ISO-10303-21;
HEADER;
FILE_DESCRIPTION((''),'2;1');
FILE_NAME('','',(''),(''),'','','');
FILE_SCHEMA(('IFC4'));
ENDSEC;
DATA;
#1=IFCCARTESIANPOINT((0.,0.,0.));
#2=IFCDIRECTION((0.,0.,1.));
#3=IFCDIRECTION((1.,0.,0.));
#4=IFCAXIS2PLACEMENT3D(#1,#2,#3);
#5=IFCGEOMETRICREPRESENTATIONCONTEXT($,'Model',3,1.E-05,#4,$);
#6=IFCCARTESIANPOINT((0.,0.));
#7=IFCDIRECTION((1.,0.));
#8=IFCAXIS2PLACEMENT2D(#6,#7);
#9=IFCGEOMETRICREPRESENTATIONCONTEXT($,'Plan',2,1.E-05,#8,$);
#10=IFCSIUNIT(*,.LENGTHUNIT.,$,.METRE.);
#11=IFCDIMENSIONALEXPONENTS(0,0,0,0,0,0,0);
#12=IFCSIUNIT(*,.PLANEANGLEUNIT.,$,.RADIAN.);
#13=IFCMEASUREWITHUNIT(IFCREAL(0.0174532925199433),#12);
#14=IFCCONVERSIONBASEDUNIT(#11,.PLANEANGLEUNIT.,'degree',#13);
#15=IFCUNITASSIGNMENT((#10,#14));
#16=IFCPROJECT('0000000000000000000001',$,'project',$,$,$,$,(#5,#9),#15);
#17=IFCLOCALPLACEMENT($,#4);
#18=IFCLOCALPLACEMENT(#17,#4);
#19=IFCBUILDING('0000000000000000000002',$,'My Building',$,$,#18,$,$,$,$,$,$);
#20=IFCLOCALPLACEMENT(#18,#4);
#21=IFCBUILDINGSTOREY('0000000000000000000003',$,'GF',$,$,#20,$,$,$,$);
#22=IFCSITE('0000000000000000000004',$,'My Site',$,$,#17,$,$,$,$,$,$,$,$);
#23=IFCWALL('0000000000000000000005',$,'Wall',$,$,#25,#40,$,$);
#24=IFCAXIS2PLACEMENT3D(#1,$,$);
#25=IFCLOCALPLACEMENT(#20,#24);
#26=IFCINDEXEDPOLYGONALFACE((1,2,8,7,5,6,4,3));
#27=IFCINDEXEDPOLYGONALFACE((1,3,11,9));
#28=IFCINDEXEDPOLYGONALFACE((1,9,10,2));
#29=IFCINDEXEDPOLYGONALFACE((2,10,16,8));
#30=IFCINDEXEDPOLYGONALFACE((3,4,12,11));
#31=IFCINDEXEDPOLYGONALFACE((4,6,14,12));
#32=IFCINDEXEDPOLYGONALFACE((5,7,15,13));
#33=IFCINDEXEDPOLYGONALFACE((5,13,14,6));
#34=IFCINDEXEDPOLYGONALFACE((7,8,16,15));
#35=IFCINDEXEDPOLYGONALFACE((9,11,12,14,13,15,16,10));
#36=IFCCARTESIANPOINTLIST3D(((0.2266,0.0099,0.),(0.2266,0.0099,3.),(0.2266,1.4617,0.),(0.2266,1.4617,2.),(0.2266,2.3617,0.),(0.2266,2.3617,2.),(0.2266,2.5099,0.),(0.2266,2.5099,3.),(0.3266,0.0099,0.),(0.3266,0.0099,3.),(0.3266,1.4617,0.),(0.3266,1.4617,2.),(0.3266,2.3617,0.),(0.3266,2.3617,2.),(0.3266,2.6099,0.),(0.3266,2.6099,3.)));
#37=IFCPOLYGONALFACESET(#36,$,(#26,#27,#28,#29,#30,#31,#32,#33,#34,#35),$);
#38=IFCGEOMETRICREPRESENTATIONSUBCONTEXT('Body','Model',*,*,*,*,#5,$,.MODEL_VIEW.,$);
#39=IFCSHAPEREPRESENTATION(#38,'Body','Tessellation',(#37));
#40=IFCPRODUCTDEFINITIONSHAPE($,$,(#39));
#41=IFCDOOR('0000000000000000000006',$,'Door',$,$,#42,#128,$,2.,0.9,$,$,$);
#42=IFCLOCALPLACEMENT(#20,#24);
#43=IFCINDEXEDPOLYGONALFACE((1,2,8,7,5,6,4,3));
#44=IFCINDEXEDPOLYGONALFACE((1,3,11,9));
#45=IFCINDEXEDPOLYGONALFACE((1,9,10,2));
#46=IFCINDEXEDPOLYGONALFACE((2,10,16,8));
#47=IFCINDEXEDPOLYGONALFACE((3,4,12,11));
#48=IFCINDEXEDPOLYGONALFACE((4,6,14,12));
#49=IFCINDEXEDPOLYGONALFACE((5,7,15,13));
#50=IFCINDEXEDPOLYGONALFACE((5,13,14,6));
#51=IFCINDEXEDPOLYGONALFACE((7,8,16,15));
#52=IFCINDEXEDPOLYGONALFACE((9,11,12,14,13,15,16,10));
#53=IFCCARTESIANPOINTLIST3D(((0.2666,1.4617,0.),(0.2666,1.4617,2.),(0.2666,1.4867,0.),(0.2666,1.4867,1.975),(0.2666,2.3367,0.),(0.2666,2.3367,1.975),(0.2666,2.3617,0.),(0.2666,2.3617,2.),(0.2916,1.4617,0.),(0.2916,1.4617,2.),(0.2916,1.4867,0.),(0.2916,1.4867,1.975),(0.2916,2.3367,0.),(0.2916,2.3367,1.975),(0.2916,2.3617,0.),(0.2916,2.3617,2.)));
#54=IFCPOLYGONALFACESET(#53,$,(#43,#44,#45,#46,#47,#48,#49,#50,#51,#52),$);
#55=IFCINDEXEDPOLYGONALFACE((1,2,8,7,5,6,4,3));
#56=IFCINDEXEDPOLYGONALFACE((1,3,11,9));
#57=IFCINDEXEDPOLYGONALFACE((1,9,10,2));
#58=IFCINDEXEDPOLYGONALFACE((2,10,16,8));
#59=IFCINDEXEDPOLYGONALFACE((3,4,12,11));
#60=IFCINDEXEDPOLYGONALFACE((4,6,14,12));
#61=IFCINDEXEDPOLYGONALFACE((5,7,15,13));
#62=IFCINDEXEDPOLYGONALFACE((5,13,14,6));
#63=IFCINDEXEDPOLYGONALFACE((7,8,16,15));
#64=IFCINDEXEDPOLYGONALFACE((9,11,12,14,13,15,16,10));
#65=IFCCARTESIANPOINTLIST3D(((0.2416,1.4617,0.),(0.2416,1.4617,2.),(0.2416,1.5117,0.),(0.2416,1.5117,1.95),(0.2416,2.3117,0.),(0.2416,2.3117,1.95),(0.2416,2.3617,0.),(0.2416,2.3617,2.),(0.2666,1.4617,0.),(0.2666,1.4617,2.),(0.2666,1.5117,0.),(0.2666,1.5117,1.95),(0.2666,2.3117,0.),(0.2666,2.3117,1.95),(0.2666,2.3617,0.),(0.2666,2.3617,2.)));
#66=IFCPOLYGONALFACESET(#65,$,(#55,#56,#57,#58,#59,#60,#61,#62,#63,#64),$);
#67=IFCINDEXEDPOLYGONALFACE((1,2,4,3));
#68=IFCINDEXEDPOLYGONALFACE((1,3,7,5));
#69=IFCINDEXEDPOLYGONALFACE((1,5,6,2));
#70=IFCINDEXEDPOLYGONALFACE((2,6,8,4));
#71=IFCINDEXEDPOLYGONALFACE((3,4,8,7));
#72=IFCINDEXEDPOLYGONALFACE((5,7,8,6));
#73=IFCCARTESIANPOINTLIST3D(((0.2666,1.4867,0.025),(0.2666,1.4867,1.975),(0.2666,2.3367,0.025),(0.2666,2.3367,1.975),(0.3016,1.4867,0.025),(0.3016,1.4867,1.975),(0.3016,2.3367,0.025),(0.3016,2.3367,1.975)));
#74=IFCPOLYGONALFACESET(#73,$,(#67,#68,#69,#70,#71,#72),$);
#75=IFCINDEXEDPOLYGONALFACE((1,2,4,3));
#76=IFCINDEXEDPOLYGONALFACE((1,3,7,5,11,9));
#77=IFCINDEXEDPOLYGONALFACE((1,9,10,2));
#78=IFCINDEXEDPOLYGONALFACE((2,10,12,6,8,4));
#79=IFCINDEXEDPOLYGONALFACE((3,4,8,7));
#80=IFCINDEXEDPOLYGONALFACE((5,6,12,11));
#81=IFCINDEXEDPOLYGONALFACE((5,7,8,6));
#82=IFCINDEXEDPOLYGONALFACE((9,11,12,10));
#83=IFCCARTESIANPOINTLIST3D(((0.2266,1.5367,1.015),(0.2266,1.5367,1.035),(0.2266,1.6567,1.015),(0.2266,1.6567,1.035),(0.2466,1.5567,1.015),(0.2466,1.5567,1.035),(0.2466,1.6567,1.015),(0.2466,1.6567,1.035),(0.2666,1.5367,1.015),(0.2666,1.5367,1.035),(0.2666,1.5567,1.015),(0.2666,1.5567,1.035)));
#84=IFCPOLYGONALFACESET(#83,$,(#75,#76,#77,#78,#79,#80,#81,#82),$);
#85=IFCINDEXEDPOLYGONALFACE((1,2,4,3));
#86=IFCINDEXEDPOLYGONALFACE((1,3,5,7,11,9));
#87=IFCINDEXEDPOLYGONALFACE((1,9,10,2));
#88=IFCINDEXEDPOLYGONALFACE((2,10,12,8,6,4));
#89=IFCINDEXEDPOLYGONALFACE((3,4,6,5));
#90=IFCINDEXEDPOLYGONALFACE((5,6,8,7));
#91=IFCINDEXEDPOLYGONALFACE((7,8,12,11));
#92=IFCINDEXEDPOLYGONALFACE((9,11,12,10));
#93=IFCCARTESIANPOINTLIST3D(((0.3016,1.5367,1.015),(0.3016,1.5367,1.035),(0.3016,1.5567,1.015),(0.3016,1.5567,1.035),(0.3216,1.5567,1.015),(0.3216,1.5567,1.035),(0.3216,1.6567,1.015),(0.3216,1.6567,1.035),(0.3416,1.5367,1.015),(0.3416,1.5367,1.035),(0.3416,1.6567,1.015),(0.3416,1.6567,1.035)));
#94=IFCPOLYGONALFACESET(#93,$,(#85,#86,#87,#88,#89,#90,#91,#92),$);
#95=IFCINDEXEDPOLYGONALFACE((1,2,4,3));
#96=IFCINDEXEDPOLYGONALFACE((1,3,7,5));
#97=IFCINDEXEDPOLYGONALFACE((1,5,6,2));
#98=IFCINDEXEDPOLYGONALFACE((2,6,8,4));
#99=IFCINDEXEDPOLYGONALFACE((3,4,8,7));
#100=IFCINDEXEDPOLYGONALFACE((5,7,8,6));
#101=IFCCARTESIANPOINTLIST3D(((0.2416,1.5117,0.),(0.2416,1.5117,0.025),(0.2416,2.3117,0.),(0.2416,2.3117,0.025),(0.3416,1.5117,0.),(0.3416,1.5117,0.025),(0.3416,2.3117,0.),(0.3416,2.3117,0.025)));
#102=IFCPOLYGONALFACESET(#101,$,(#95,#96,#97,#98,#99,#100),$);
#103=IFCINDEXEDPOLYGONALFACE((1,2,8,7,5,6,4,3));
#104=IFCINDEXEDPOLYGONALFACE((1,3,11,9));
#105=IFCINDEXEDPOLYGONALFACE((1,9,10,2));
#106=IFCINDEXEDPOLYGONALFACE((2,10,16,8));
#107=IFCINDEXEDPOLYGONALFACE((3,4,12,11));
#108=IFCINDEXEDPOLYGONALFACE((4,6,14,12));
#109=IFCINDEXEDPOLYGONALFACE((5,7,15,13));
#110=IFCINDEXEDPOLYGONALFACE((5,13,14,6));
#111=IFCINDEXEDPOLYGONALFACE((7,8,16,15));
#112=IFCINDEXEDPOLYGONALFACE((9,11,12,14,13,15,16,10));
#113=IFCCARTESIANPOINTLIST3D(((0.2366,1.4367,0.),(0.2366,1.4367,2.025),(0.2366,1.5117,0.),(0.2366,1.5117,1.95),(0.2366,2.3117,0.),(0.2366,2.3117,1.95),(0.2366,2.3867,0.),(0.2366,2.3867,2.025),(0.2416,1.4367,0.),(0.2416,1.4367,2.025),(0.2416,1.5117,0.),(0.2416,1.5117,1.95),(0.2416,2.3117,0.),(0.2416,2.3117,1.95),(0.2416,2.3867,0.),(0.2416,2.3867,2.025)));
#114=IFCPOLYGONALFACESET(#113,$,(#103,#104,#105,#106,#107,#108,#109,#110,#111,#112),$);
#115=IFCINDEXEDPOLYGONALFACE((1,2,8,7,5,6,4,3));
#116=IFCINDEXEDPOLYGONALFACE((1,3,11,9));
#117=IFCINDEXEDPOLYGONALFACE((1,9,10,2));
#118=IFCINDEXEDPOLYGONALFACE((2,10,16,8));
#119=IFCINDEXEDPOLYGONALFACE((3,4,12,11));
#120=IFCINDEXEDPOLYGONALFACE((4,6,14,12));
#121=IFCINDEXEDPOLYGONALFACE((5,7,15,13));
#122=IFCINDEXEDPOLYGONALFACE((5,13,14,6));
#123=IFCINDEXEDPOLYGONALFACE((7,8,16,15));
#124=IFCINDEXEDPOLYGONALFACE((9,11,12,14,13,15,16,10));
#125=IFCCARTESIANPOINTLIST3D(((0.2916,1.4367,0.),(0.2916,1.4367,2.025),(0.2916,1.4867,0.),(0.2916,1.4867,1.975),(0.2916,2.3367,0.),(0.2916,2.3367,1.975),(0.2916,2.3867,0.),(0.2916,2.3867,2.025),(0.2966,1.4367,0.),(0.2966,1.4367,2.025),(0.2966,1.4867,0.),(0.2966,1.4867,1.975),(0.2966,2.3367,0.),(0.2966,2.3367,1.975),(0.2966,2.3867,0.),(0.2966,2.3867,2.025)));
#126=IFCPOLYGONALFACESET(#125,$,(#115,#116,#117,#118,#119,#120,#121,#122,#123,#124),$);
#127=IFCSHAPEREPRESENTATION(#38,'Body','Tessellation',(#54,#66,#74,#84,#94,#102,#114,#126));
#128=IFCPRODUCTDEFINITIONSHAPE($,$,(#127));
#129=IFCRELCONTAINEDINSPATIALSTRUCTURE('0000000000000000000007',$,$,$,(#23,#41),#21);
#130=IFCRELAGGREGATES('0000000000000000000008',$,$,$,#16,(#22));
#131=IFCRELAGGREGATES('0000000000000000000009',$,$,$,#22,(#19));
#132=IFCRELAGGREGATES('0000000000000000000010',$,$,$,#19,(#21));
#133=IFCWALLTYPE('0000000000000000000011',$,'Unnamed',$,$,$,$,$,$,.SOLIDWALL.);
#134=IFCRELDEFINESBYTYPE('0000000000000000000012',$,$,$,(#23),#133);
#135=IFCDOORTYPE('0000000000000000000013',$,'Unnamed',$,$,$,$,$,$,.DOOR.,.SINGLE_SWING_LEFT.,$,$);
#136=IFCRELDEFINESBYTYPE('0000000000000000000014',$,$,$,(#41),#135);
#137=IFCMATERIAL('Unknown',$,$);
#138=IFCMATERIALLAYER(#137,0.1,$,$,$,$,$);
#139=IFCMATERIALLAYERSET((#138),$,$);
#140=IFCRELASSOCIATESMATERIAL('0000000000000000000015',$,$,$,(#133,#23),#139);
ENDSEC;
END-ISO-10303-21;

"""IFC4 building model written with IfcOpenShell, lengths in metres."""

from ifc_helpers import new_model, entity, si_unit, converted_unit, frame, origin_with_axes, origin_2d_with_axis, place, context, subcontext, project, spatial, line, indexed_curve, outline, extrude, shape, source, transform, mapped, material, layer, layer_set, layer_usage, type_object, type_shapes, element, fill, save


model = new_model("IFC4")

# Units and contexts
model_context = context("Model", 3, precision=1e-05, world=origin_with_axes())
plan_context = context("Plan", 2, precision=1e-05, world=origin_2d_with_axis())
body_context_1 = subcontext(model_context, "Body", "Model", "MODEL_VIEW")
body_context_2 = subcontext(plan_context, "Body", "Plan", "PLAN_VIEW")
ifc_project = project(units=[si_unit("LENGTHUNIT", "METRE"), converted_unit("PLANEANGLEUNIT", "degree", entity("IfcReal", 0.0174532925199433), si_unit("PLANEANGLEUNIT", "RADIAN"), dimensions=[0, 0, 0, 0, 0, 0, 0])], contexts=[model_context, plan_context])

# Site, building, storey
site_placement = place(None, origin_with_axes())
site = spatial("IfcSite", under=ifc_project, at=site_placement, Name="My Site")
building_placement = place(site_placement, origin_with_axes())
building = spatial("IfcBuilding", under=site, at=building_placement, Name="My Building")
storey_placement = place(building_placement, origin_with_axes())
storey = spatial("IfcBuildingStorey", under=building, at=storey_placement, Name="GF")

# Shared definitions
ifc_material = material(Name="Unknown")

# Shared definitions
ifc_layer_1 = layer(ifc_material, 0.1)
ifc_layer_set_1 = layer_set([ifc_layer_1])
wall_type = type_object("IfcWallType", Name="Unnamed", PredefinedType="SOLIDWALL", material=ifc_layer_set_1)
shared_shape_1 = source(origin_with_axes(), body_context_1, "Body", "SweptSolid", [
    extrude(outline(indexed_curve([(0.0, 0.0), (0.9, 0.0), (0.9, 2.0), (0.0, 2.0)], segments=[line(1, 2, 3, 4, 1)])), frame((0.0, -0.6, 0.0), z_axis=(0.0, -1.0, 0.0), x_axis=(1.0, 0.0, 0.0)), (0.0, 0.0, -1.0), 1.2),
])
door_type_1 = type_object("IfcDoorType", Name="Unnamed", OperationType="SINGLE_SWING_LEFT", PredefinedType="DOOR")
shared_shape_2 = source(origin_with_axes(), body_context_1, "Body", "SweptSolid", [
    extrude(outline(indexed_curve([(0.0, 0.0), (0.0, 2.0), (0.9, 2.0), (0.9, 0.0), (0.875, 0.0), (0.875, 1.975), (0.025, 1.975), (0.025, 0.0)], segments=[line(1, 2, 3, 4, 5, 6, 7, 8, 1)])), frame((0.0, 0.025, 0.0), z_axis=(0.0, -1.0, 0.0), x_axis=(1.0, 0.0, 0.0)), (0.0, 0.0, -1.0), 0.025),
    extrude(outline(indexed_curve([(0.0, 0.0), (0.0, 2.0), (0.9, 2.0), (0.9, 0.0), (0.85, 0.0), (0.85, 1.95), (0.05, 1.95), (0.05, 0.0)], segments=[line(1, 2, 3, 4, 5, 6, 7, 8, 1)])), frame((0.0, 0.0, 0.0), z_axis=(0.0, -1.0, 0.0), x_axis=(1.0, 0.0, 0.0)), (0.0, 0.0, -1.0), 0.025),
    extrude(outline(indexed_curve([(0.0, 0.0), (0.85, 0.0), (0.85, 0.035), (0.0, 0.035)], segments=[line(1, 2, 3, 4, 1)])), frame((0.025, 0.025, 0.025), z_axis=(0.0, 0.0, 1.0), x_axis=(1.0, 0.0, 0.0)), (0.0, 0.0, 1.0), 1.95),
    extrude(outline(indexed_curve([(0.0, 0.0), (0.0, -0.04), (-0.12, -0.04), (-0.12, -0.02), (-0.02, -0.02), (-0.02, 0.0)], segments=[line(1, 2, 3, 4, 5, 6, 1)])), frame((0.825, 0.025, 1.015), z_axis=(0.0, 0.0, 1.0), x_axis=(1.0, 0.0, 0.0)), (0.0, 0.0, 1.0), 0.02),
    extrude(outline(indexed_curve([(0.0, 0.0), (0.0, 0.04), (-0.12, 0.04), (-0.12, 0.02), (-0.02, 0.02), (-0.02, 0.0)], segments=[line(1, 2, 3, 4, 5, 6, 1)])), frame((0.825, 0.06, 1.015), z_axis=(0.0, 0.0, 1.0), x_axis=(1.0, 0.0, 0.0)), (0.0, 0.0, 1.0), 0.02),
    extrude(outline(indexed_curve([(0.0, 0.0), (0.8, 0.0), (0.8, 0.1), (0.0, 0.1)], segments=[line(1, 2, 3, 4, 1)])), frame((0.05, 0.0, 0.0), z_axis=(0.0, 0.0, 1.0), x_axis=(1.0, 0.0, 0.0)), (0.0, 0.0, 1.0), 0.025),
    extrude(outline(indexed_curve([(0.0, 0.0), (0.0, 2.025), (0.95, 2.025), (0.95, 0.0), (0.875, 0.0), (0.875, 1.95), (0.075, 1.95), (0.075, 0.0)], segments=[line(1, 2, 3, 4, 5, 6, 7, 8, 1)])), frame((-0.025, -0.005, 0.0), z_axis=(0.0, -1.0, 0.0), x_axis=(1.0, 0.0, 0.0)), (0.0, 0.0, -1.0), 0.005),
    extrude(outline(indexed_curve([(0.0, 0.0), (0.0, 2.025), (0.95, 2.025), (0.95, 0.0), (0.9, 0.0), (0.9, 1.975), (0.05, 1.975), (0.05, 0.0)], segments=[line(1, 2, 3, 4, 5, 6, 7, 8, 1)])), frame((-0.025, 0.05, 0.0), z_axis=(0.0, -1.0, 0.0), x_axis=(1.0, 0.0, 0.0)), (0.0, 0.0, -1.0), 0.005),
])
shared_shape_3 = source(origin_with_axes(), body_context_2, "Body", "Curve2D", [
    entity("IfcIndexedPolyCurve", entity("IfcCartesianPointList2D", [[0.0, 0.0], [0.0, 0.05], [0.025, 0.05], [0.025, 0.025], [0.05, 0.025], [0.05, 0.0]]), [entity("IfcLineIndex", [1, 2, 3, 4, 5, 6, 1])]),
    entity("IfcIndexedPolyCurve", entity("IfcCartesianPointList2D", [[0.9, 0.0], [0.9, 0.05], [0.875, 0.05], [0.875, 0.025], [0.85, 0.025], [0.85, 0.0]]), [entity("IfcLineIndex", [1, 2, 3, 4, 5, 6, 1])]),
    entity("IfcTrimmedCurve", entity("IfcEllipse", entity("IfcAxis2Placement2D", entity("IfcCartesianPoint", [0.06, 0.05]), entity("IfcDirection", [1.0, 0.0])), 0.815, 0.85), [entity("IfcCartesianPoint", [0.875, 0.05])], [entity("IfcCartesianPoint", [0.06, 0.9])], True, "CARTESIAN"),
    entity("IfcIndexedPolyCurve", entity("IfcCartesianPointList2D", [[0.025, 0.05], [0.06, 0.05], [0.06, 0.9], [0.025, 0.9]]), [entity("IfcLineIndex", [1, 2, 3, 4, 1])]),
])
type_shapes(door_type_1, [shared_shape_2, shared_shape_3])

# Wall, opening, door
ifc_layer_usage_1 = layer_usage(ifc_layer_set_1, "AXIS2", "POSITIVE", 0.0)
wall_1_placement = place(storey_placement, frame((0.3266, 0.0099, 0.0), z_axis=(0.0, 0.0, 1.0), x_axis=(0.0, 1.0, 0.0)))
wall_1 = element("IfcWall", 1, at=wall_1_placement, inside=storey, type_object=wall_type, material=ifc_layer_usage_1, Name="Wall", context=body_context_1, shape_type="SweptSolid", body=[
    extrude(outline(indexed_curve([(0.0, 0.0), (0.0, 0.1), (2.5, 0.1), (2.6, 0.0)], segments=[line(1, 2, 3, 4, 1)])), origin_with_axes(), (0.0, 0.0, 1.0), 3.0),
])
opening_1_placement = place(wall_1_placement, frame((1.4518, 0.0, 0.0), z_axis=(0.0, 0.0, 1.0), x_axis=(1.0, 0.0, 0.0)))
opening_1 = element("IfcOpeningElement", 2, at=opening_1_placement, cuts=wall_1, PredefinedType="OPENING", context=body_context_1, shape_type="MappedRepresentation", body=[
    mapped(shared_shape_1, transform((0.0, 0.0, 0.0), x_axis=(1.0, 0.0, 0.0), y_axis=(0.0, 1.0, 0.0), z_axis=(0.0, 0.0, 1.0), scale=1.0)),
])
door_1_placement = place(opening_1_placement, frame((0.9, 0.085, 0.0), z_axis=(0.0, 0.0, 1.0), x_axis=(-1.0, 0.0, 0.0)))
door_1 = element("IfcDoor", 3, at=door_1_placement, inside=storey, type_object=door_type_1, Name="Door", OverallHeight=2.0, OverallWidth=0.9, shapes=[
    shape(body_context_1, "Body", "MappedRepresentation", [mapped(shared_shape_2, transform((0.0, 0.0, 0.0), x_axis=(1.0, 0.0, 0.0), y_axis=(0.0, 1.0, 0.0), z_axis=(0.0, 0.0, 1.0), scale=1.0))]),
    shape(body_context_2, "Body", "MappedRepresentation", [mapped(shared_shape_3, transform((0.0, 0.0, 0.0), x_axis=(1.0, 0.0, 0.0), y_axis=(0.0, 1.0, 0.0), z_axis=(0.0, 0.0, 1.0), scale=1.0))]),
])
fill(opening_1, door_1)

save(model, "model.ifc")
